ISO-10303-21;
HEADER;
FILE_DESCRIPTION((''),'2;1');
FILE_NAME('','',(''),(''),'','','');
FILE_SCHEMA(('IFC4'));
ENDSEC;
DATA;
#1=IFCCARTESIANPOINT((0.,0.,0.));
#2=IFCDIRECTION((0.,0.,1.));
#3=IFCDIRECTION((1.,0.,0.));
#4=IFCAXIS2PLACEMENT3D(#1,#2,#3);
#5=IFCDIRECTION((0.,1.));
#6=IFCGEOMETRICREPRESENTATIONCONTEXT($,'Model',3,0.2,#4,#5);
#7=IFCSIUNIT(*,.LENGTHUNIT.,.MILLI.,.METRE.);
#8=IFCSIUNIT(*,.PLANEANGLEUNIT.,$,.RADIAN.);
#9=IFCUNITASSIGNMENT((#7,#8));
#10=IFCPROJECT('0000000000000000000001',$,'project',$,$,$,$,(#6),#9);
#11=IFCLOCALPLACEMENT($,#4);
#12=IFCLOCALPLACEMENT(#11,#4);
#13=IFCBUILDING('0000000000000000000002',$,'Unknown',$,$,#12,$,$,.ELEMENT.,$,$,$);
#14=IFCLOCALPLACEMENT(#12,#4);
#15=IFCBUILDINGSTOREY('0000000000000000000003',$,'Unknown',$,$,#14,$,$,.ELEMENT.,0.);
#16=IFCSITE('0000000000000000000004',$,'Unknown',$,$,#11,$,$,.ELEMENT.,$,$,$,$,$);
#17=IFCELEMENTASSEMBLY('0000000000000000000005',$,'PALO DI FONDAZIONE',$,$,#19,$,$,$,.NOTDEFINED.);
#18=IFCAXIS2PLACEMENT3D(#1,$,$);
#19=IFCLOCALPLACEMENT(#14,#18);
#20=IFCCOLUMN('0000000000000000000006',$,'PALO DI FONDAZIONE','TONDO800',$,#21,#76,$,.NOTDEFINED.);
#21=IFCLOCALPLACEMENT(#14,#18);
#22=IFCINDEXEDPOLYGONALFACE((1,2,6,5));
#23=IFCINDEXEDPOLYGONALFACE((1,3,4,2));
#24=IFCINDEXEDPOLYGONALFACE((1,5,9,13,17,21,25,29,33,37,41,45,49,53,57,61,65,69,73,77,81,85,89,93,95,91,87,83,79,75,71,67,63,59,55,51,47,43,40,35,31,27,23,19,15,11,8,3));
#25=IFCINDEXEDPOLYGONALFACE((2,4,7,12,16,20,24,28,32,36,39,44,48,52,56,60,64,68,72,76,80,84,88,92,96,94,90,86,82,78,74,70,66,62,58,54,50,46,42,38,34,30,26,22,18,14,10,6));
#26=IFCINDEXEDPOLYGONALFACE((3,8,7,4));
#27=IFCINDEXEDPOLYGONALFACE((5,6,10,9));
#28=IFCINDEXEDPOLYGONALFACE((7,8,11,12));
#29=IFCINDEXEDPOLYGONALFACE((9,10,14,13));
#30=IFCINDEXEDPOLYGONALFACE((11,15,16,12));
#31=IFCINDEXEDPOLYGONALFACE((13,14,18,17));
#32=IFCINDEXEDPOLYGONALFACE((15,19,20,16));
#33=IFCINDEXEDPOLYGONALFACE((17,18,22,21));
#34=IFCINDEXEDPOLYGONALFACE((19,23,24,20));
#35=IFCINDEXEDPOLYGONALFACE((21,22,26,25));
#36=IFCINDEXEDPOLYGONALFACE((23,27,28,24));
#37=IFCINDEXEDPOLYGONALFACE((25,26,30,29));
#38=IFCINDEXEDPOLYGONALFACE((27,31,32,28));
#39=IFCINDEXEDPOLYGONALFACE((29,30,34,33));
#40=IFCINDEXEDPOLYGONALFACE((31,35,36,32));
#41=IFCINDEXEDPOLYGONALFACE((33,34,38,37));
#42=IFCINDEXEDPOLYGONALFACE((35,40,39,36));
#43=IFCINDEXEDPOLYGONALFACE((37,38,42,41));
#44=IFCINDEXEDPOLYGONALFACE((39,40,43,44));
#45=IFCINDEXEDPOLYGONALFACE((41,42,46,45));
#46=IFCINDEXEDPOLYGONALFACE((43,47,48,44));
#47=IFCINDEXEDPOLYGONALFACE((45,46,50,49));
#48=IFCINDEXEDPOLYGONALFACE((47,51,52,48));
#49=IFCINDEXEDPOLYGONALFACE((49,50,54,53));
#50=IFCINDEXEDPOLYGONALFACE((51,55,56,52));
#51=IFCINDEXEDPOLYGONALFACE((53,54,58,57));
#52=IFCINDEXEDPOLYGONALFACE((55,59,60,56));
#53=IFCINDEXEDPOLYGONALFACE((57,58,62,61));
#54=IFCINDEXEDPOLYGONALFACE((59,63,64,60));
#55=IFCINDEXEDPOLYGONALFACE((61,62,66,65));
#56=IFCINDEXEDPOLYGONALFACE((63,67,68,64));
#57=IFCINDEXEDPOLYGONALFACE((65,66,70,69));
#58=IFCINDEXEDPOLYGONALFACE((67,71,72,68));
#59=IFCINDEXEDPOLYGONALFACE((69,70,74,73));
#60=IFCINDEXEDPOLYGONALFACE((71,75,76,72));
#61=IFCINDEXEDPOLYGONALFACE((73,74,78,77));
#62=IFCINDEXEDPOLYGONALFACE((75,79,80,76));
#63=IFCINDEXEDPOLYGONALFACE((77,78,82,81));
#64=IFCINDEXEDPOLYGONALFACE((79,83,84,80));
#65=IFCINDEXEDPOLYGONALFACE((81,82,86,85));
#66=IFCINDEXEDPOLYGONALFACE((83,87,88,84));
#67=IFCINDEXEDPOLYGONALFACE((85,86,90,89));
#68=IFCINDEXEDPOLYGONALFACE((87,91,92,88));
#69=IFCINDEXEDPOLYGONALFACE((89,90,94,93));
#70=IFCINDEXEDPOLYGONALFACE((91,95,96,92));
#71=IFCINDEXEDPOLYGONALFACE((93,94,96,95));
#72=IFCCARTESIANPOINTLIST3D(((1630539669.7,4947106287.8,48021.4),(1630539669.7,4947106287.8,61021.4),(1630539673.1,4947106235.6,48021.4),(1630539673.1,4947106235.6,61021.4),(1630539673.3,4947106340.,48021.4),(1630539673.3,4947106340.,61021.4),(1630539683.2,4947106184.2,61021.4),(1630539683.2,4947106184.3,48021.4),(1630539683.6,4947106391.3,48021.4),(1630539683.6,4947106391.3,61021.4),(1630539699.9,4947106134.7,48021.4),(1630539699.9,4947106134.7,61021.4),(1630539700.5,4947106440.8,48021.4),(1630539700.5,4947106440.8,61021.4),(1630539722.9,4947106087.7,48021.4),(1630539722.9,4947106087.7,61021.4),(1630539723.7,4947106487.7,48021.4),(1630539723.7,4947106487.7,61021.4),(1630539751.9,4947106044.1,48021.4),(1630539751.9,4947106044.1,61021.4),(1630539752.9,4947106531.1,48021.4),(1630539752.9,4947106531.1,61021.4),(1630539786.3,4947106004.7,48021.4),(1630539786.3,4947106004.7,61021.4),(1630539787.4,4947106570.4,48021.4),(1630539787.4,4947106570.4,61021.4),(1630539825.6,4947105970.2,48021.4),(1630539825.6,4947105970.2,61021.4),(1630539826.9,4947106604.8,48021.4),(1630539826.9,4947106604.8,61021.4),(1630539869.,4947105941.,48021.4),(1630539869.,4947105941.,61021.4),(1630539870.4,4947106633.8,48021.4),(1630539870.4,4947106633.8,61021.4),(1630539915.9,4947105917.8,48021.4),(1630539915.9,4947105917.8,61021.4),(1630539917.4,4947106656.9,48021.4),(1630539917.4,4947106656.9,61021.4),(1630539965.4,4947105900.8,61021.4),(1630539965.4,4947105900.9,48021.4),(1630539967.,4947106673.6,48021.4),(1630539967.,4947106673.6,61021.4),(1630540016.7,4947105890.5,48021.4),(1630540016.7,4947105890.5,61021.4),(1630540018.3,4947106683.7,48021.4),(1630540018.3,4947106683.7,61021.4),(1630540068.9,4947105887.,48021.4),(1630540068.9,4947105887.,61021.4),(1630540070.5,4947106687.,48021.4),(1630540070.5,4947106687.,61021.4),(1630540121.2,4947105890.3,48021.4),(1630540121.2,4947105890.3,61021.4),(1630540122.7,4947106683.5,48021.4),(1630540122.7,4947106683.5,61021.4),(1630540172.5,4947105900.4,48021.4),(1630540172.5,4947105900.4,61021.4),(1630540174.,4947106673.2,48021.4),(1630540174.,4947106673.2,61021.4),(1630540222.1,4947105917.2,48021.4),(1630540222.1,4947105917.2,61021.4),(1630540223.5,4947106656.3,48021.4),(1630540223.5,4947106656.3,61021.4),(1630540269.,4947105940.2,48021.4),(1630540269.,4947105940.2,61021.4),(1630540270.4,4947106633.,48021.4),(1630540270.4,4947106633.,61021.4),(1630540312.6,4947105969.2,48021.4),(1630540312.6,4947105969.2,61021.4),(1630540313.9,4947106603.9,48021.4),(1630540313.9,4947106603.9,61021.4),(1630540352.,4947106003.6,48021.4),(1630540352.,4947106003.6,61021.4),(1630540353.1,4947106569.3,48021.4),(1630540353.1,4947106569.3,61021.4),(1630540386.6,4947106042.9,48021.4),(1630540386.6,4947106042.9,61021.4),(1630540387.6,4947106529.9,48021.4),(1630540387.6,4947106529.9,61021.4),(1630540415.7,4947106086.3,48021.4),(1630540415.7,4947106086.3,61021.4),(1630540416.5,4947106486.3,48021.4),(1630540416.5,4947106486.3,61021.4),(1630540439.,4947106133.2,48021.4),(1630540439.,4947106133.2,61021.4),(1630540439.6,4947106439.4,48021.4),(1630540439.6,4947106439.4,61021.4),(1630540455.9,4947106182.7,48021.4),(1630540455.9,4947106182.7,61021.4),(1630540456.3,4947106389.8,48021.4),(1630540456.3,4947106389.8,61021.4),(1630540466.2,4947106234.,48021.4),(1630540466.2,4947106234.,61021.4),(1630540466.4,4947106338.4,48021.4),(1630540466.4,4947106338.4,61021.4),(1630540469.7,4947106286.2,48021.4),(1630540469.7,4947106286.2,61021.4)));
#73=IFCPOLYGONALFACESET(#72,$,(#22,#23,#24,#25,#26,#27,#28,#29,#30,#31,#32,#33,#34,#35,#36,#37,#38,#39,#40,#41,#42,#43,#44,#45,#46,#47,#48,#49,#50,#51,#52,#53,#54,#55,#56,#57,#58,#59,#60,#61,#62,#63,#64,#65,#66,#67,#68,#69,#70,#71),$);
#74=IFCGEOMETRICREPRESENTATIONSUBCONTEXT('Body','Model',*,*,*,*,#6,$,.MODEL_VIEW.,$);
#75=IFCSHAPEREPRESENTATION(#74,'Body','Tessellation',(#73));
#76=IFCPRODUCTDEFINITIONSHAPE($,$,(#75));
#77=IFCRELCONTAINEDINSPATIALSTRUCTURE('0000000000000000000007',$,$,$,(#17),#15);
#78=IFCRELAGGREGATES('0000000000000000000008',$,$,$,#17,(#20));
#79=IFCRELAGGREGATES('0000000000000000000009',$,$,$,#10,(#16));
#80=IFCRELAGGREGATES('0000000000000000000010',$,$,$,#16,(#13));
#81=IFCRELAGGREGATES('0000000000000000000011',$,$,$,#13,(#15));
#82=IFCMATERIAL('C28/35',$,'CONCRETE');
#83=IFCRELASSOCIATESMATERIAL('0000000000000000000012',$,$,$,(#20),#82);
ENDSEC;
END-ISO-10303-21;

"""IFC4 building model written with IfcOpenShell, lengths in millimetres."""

from ifc_helpers import new_model, si_unit, direction, frame, origin_with_axes, place, context, subcontext, project, spatial, line, indexed_curve, outline, extrude, material, element, aggregate, save


model = new_model("IFC4")

# Units and contexts
model_context = context("Model", 3, precision=0.2, world=origin_with_axes(), true_north=direction((0.0, 1.0)))
body_context = subcontext(model_context, "Body", "Model", "MODEL_VIEW")
ifc_project = project(units=[si_unit("LENGTHUNIT", "METRE", prefix="MILLI"), si_unit("PLANEANGLEUNIT", "RADIAN")], contexts=[model_context])

# Site, building, storey
site_placement = place(None, origin_with_axes())
site = spatial("IfcSite", under=ifc_project, at=site_placement, Name="Unknown", CompositionType="ELEMENT")
building_placement = place(site_placement, origin_with_axes())
building = spatial("IfcBuilding", under=site, at=building_placement, Name="Unknown", CompositionType="ELEMENT")
storey_placement = place(building_placement, origin_with_axes())
storey = spatial("IfcBuildingStorey", under=building, at=storey_placement, Name="Unknown", CompositionType="ELEMENT", Elevation=0.0)

# Element assembly, column
ifc_material_1 = material(Name="C28/35", Category="CONCRETE")
assembly_1_placement = place(storey_placement, frame((1630540069.7, 4947106287.0, 48021.4), z_axis=(0.705709, -0.708501, 0.0), x_axis=(0.0, 0.0, 1.0)))
assembly_1 = element("IfcElementAssembly", 1, at=assembly_1_placement, inside=storey, Name="PALO DI FONDAZIONE", PredefinedType="NOTDEFINED")
column_1_placement = place(assembly_1_placement, origin_with_axes())
column_1 = element("IfcColumn", 2, at=column_1_placement, material=ifc_material_1, Name="PALO DI FONDAZIONE", Description="TONDO800", PredefinedType="NOTDEFINED", context=body_context, shape_type="SolidModel", body=[
    extrude(outline(indexed_curve([(400.0, 0.0), (396.6, 52.2), (386.4, 103.5), (369.6, 153.1), (346.4, 200.0), (317.3, 243.5), (282.8, 282.8), (243.5, 317.3), (200.0, 346.4), (153.1, 369.6), (103.5, 386.4), (52.2, 396.6), (0.0, 400.0), (-52.2, 396.6), (-103.5, 386.4), (-153.1, 369.6), (-200.0, 346.4), (-243.5, 317.3), (-282.8, 282.8), (-317.3, 243.5), (-346.4, 200.0), (-369.6, 153.1), (-386.4, 103.5), (-396.6, 52.2), (-400.0, 0.0), (-396.6, -52.2), (-386.4, -103.5), (-369.6, -153.1), (-346.4, -200.0), (-317.3, -243.5), (-282.8, -282.8), (-243.5, -317.3), (-200.0, -346.4), (-153.1, -369.6), (-103.5, -386.4), (-52.2, -396.6), (0.0, -400.0), (52.2, -396.6), (103.5, -386.4), (153.1, -369.6), (200.0, -346.4), (243.5, -317.3), (282.8, -282.8), (317.3, -243.5), (346.4, -200.0), (369.6, -153.1), (386.4, -103.5), (396.6, -52.2)], segments=[line(1, 2, 3, 4, 5, 6, 7, 8, 9, 10, 11, 12, 13, 14, 15, 16, 17, 18, 19, 20, 21, 22, 23, 24, 25, 26, 27, 28, 29, 30, 31, 32, 33, 34, 35, 36, 37, 38, 39, 40, 41, 42, 43, 44, 45, 46, 47, 48, 1)])), frame((0.0, 0.0, 0.0), z_axis=(-1.0, 0.0, 0.0), x_axis=(0.0, 0.0, 1.0)), (0.0, 0.0, -1.0), 13000.0),
])
aggregate(assembly_1, [column_1])

save(model, "model.ifc")
